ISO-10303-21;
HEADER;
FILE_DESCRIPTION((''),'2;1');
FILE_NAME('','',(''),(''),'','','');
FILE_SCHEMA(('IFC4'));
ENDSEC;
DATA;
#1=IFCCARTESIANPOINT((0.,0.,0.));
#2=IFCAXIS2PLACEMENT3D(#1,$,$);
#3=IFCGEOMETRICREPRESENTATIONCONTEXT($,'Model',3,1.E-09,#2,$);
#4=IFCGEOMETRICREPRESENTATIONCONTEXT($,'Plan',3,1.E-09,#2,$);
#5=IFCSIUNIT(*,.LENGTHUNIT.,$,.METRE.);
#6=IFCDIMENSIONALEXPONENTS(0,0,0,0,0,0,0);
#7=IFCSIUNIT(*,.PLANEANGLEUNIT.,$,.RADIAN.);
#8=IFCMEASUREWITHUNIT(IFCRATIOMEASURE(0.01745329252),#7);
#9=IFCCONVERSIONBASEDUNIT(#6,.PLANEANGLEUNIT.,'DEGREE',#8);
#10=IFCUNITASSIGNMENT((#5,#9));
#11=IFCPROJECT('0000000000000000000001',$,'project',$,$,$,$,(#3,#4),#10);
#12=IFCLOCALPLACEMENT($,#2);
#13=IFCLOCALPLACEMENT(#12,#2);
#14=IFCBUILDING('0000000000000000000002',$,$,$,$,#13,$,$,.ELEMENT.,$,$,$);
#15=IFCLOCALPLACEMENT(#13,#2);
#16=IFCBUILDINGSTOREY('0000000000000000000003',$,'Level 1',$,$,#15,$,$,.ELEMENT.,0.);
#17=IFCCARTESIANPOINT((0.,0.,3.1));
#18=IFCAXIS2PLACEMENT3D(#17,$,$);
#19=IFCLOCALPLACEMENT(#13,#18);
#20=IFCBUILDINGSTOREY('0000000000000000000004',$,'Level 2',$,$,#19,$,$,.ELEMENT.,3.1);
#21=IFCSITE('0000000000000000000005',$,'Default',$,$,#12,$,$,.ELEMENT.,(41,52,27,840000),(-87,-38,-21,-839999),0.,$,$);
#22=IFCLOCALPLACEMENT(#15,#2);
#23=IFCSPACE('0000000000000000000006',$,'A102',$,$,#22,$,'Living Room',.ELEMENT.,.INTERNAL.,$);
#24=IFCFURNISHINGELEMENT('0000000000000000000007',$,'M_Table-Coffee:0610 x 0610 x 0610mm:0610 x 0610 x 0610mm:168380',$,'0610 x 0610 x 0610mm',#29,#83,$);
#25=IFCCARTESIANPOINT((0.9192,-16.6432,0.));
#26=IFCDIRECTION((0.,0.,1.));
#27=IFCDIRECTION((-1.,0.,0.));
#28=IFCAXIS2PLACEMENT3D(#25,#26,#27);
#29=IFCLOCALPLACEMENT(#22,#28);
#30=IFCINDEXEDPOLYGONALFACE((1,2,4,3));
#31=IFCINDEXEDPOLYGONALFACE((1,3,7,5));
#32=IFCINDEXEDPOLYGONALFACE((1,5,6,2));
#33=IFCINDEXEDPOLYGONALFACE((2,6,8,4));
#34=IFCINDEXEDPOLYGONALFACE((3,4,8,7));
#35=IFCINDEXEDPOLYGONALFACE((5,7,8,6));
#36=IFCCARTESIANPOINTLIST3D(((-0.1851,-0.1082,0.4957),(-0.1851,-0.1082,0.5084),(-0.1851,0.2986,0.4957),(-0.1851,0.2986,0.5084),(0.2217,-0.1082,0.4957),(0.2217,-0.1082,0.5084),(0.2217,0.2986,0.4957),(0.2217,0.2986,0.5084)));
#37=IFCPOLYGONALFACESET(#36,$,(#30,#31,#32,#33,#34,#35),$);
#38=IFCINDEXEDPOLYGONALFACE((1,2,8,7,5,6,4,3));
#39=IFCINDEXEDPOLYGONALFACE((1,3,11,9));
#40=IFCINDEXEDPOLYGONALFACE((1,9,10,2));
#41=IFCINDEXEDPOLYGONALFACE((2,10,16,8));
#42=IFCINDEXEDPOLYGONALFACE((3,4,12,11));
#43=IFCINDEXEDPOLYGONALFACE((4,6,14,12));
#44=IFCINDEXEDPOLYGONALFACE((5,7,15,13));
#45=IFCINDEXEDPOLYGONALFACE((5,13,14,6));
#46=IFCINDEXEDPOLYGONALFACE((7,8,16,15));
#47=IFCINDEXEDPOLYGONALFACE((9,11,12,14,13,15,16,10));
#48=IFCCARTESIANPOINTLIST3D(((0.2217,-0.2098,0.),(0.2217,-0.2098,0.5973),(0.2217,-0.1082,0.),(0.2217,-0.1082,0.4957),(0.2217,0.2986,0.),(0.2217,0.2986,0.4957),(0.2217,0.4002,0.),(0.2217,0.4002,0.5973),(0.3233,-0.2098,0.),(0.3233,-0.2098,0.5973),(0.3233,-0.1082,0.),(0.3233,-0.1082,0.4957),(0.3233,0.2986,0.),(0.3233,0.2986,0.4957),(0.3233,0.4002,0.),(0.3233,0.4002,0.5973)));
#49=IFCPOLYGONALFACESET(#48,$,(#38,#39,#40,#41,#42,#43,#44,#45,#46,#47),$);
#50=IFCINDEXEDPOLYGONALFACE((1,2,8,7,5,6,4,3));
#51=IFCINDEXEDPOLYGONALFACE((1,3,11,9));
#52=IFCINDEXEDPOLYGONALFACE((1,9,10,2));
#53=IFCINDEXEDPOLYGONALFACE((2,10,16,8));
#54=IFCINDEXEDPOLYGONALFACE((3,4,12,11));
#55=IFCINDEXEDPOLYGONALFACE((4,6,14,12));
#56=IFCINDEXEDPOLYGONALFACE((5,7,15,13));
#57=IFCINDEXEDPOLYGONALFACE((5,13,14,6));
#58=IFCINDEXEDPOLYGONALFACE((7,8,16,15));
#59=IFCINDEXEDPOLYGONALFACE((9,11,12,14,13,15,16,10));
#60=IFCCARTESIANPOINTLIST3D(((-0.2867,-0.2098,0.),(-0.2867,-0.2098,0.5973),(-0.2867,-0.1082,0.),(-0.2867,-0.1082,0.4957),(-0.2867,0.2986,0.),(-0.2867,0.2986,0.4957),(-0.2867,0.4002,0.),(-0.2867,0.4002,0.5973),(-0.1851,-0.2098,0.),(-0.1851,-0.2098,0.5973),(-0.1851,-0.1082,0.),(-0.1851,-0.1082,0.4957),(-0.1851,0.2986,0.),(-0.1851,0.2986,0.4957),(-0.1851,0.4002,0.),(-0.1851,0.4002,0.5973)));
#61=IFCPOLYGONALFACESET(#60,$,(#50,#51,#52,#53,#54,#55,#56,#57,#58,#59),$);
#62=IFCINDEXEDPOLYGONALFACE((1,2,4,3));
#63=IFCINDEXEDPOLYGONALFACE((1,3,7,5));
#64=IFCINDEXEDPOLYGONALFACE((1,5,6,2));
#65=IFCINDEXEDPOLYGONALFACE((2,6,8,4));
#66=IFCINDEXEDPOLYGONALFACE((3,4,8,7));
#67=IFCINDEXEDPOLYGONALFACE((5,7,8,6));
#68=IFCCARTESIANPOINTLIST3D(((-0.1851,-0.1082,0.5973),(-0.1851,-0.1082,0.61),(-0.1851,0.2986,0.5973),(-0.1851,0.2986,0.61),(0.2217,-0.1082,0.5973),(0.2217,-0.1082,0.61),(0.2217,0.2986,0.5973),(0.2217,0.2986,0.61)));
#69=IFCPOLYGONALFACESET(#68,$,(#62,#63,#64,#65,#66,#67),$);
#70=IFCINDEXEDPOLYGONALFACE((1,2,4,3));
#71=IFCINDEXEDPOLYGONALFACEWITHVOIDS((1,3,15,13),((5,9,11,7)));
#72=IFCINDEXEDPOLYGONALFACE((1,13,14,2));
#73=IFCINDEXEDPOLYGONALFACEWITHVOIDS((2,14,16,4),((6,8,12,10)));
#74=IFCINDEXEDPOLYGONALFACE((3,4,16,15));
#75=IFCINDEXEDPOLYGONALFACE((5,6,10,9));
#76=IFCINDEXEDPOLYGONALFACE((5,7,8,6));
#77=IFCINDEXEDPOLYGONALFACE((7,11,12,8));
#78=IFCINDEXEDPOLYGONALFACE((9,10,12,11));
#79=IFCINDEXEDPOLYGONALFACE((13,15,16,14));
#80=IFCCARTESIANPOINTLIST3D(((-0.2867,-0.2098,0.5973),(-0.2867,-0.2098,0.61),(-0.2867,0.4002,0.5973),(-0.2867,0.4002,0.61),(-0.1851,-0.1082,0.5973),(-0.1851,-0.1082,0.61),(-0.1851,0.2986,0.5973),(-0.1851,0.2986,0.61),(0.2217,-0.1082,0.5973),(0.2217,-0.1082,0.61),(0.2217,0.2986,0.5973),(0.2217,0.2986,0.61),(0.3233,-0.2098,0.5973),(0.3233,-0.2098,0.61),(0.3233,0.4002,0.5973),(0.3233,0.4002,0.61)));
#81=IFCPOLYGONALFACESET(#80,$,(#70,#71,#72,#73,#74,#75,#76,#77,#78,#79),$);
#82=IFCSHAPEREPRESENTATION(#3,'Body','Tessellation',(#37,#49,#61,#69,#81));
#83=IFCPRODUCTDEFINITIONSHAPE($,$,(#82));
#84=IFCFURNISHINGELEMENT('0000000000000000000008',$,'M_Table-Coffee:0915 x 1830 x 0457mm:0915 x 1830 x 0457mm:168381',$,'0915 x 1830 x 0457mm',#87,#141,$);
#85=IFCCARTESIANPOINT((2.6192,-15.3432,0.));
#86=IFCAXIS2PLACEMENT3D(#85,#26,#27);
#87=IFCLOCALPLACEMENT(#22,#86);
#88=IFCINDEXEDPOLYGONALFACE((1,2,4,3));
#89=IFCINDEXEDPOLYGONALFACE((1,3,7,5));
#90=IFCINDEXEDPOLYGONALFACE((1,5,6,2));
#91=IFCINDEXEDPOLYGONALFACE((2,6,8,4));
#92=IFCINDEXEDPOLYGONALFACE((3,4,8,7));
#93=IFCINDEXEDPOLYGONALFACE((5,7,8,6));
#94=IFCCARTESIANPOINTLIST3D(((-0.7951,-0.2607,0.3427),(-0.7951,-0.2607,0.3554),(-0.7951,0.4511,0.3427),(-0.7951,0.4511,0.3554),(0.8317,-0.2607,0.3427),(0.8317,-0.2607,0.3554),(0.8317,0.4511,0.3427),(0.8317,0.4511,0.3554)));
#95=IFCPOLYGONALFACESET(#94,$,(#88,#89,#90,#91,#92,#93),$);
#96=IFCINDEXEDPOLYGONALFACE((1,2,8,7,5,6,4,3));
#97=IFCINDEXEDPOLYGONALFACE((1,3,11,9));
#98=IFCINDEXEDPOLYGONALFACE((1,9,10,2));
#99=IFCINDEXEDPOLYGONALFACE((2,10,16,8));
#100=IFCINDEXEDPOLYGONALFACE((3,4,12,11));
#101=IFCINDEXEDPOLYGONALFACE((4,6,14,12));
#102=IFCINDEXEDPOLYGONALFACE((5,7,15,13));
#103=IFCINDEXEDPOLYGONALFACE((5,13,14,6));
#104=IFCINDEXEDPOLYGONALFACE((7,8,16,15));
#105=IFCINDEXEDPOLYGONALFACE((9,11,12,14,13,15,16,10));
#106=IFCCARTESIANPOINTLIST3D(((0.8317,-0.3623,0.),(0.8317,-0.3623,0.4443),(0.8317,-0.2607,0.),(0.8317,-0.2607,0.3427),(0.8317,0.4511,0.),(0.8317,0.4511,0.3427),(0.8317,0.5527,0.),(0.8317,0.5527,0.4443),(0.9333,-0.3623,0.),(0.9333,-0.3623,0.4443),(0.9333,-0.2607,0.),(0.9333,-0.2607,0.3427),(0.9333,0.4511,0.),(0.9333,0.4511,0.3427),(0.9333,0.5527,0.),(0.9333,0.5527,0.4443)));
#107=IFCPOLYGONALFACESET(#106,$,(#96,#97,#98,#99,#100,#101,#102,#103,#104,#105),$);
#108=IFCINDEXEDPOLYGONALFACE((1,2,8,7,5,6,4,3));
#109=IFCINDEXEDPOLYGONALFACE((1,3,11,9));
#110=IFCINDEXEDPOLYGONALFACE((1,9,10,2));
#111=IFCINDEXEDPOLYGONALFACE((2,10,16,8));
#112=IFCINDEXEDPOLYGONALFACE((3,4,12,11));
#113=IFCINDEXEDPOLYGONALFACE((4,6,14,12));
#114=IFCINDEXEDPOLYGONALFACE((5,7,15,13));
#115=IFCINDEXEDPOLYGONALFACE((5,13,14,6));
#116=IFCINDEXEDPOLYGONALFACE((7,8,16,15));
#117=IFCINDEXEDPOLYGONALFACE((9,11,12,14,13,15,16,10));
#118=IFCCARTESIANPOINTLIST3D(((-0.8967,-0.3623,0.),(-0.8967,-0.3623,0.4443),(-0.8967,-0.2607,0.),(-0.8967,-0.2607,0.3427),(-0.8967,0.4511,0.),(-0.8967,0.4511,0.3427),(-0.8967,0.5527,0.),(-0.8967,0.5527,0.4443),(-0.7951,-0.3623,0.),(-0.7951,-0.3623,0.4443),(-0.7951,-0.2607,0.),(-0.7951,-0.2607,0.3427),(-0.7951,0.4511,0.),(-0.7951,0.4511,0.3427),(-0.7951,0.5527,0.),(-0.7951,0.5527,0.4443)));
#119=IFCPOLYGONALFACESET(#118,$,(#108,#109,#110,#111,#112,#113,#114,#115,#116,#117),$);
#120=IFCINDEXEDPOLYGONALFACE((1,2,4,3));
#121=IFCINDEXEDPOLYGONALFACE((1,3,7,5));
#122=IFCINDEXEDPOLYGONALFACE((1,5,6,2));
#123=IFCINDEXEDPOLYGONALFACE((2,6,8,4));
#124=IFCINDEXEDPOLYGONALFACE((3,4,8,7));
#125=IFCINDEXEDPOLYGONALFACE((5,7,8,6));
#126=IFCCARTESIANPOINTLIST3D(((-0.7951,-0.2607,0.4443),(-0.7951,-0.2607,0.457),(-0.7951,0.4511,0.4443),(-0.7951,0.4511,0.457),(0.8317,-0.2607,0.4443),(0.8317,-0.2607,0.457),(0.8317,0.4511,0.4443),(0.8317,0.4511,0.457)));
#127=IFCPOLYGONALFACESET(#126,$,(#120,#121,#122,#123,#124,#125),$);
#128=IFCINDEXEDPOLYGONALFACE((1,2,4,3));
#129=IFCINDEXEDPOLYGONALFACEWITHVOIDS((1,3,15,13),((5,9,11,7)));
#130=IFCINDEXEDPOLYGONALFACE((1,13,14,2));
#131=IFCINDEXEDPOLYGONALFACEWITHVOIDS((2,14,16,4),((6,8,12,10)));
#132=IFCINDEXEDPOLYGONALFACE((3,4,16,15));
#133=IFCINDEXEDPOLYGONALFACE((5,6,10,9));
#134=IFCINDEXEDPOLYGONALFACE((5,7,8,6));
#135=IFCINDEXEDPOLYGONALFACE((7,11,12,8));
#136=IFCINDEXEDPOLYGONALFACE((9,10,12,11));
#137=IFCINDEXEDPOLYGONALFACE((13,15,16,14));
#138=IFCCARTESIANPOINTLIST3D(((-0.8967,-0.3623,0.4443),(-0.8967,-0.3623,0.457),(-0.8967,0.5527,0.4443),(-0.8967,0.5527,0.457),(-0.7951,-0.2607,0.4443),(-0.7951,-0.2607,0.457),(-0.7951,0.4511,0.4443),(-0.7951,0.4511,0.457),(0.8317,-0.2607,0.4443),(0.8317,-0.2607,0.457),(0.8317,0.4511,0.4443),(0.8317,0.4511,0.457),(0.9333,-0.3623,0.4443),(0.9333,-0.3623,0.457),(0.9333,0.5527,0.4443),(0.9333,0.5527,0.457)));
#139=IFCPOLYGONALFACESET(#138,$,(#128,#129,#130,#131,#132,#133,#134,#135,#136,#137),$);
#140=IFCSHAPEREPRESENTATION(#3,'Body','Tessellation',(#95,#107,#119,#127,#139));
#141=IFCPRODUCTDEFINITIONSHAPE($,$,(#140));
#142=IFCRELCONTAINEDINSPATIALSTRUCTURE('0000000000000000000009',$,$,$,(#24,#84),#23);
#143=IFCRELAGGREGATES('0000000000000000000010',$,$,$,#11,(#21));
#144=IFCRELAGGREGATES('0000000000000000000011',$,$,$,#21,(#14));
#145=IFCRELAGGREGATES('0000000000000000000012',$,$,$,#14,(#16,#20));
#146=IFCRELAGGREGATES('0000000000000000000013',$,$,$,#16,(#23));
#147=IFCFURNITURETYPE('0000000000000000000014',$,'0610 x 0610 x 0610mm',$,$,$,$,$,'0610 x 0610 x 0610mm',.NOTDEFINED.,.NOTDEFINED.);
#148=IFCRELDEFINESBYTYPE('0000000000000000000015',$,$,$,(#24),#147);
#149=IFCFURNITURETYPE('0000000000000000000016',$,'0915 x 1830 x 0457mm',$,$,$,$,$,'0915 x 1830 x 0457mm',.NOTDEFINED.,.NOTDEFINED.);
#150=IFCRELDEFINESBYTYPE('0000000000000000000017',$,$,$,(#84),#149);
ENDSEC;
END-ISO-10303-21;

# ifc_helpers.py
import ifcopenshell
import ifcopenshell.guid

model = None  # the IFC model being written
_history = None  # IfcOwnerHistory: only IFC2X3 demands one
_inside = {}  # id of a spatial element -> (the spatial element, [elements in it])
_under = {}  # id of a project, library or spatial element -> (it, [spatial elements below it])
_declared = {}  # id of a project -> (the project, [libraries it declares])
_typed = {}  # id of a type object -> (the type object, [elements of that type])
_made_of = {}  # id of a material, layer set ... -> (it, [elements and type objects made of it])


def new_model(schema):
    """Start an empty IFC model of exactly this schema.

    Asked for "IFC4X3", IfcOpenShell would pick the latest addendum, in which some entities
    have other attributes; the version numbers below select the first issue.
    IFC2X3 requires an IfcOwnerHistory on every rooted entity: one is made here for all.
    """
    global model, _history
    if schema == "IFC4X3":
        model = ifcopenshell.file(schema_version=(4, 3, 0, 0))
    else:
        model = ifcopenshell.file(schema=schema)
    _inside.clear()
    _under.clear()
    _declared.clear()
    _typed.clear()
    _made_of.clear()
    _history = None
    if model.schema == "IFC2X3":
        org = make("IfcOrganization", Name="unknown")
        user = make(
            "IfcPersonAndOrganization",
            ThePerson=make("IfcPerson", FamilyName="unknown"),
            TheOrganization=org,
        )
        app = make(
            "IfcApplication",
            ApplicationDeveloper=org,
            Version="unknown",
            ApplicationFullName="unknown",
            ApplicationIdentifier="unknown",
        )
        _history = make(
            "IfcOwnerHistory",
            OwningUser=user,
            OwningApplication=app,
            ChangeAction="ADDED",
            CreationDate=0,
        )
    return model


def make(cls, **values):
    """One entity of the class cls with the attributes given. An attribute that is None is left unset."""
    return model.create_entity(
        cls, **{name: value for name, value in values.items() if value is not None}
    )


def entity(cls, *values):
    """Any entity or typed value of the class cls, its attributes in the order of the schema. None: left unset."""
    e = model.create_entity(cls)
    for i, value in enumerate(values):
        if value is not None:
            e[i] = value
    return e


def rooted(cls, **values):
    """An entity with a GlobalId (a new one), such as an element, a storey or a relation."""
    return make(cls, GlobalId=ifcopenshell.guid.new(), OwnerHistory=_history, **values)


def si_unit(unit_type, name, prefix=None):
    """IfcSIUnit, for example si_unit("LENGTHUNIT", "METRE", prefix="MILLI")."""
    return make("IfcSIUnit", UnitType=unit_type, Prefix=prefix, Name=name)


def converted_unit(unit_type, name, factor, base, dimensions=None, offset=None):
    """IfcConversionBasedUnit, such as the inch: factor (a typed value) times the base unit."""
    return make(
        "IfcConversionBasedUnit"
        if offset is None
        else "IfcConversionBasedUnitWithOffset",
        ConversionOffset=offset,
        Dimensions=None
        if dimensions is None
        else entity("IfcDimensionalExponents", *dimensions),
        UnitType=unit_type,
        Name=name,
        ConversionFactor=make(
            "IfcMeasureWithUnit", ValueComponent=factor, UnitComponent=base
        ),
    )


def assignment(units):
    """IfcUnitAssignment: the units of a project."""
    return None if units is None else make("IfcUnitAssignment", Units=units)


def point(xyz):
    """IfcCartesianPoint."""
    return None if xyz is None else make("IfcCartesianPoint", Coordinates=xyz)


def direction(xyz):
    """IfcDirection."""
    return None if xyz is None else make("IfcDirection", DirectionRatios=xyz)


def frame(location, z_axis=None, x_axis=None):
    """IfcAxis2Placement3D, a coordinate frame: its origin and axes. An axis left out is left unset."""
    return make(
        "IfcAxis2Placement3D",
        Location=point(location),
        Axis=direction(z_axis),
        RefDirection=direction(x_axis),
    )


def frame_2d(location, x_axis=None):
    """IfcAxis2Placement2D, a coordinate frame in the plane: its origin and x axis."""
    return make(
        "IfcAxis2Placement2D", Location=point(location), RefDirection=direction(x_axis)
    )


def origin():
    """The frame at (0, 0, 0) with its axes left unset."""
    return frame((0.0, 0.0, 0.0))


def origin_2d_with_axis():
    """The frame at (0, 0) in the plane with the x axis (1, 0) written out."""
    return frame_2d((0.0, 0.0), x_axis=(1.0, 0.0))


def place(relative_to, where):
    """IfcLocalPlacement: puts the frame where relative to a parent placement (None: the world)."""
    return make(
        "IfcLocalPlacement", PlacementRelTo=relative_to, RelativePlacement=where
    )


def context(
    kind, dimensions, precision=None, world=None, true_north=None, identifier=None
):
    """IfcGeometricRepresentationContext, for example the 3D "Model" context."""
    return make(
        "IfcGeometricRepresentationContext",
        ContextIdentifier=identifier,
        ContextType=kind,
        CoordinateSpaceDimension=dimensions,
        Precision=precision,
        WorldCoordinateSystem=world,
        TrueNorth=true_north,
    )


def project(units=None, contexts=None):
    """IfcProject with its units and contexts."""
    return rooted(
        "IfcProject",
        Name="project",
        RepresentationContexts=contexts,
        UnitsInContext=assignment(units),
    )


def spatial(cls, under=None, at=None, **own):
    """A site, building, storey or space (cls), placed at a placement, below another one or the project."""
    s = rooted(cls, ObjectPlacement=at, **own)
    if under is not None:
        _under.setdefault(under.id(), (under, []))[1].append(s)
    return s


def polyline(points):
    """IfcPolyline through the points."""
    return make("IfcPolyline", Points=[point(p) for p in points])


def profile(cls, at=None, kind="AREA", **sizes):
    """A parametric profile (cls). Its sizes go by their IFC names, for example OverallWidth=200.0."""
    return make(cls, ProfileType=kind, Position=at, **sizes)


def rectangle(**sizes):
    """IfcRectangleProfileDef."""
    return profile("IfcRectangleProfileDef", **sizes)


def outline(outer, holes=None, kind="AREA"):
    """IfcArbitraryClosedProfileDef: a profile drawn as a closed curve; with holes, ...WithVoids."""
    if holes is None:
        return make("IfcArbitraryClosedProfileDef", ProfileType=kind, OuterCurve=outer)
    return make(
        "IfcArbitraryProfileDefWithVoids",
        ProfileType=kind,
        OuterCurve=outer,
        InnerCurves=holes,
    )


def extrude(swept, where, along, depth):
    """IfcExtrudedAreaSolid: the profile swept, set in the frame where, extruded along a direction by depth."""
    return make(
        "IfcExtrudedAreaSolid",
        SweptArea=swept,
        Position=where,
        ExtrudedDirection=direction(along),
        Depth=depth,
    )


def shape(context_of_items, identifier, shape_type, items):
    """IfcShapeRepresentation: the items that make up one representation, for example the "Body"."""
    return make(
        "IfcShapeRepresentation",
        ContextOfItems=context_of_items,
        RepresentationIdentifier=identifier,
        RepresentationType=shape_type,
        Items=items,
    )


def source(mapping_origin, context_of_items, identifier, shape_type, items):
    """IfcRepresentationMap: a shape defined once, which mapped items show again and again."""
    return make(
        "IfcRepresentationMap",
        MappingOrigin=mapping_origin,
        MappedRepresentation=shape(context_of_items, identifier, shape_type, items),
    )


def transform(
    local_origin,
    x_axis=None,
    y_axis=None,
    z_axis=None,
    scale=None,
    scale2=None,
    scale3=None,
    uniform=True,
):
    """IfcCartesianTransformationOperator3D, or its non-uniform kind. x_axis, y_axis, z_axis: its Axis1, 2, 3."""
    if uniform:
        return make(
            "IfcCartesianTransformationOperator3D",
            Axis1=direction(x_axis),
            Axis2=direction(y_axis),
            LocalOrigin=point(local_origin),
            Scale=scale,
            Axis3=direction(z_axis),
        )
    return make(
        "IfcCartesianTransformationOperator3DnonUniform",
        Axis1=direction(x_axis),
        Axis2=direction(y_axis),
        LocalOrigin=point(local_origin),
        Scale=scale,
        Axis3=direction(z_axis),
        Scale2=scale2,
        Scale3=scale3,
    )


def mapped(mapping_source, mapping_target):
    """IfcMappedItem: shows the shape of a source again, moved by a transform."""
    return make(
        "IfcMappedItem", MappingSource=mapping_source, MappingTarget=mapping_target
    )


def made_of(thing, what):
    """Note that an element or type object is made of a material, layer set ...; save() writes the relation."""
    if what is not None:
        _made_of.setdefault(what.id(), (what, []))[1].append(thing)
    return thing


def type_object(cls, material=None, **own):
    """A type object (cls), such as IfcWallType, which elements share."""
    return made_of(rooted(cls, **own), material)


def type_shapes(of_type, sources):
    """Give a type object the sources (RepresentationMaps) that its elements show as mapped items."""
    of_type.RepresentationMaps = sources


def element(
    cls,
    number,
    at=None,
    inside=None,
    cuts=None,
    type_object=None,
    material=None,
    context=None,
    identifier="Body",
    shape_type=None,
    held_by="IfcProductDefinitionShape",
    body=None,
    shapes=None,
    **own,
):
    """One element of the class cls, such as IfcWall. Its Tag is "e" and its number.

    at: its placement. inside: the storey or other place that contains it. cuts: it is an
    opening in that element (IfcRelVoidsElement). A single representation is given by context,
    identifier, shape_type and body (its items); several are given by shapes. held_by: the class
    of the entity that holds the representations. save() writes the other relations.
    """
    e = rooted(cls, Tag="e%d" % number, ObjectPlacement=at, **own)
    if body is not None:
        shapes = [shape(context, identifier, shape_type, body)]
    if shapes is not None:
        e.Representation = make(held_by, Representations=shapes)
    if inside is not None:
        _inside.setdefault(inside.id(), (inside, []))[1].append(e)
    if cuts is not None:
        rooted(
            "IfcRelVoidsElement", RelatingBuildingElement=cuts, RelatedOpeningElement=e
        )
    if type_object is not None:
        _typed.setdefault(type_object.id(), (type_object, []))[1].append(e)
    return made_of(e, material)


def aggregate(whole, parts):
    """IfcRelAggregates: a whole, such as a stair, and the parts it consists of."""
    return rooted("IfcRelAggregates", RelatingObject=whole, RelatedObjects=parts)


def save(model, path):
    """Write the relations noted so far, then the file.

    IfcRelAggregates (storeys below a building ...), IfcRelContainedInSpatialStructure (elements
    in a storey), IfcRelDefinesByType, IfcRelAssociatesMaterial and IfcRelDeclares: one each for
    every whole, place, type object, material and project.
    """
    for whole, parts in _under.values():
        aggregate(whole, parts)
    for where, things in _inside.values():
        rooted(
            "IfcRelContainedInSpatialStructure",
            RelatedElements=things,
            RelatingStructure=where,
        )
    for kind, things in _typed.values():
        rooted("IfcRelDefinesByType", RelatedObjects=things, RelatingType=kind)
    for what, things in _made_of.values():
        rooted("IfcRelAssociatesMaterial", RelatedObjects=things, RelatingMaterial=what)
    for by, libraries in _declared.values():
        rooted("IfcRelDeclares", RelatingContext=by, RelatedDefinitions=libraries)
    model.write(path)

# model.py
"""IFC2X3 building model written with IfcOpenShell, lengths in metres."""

from ifc_helpers import new_model, entity, si_unit, converted_unit, frame, origin, origin_2d_with_axis, place, context, project, spatial, polyline, rectangle, outline, extrude, source, transform, mapped, type_object, type_shapes, element, save


model = new_model("IFC2X3")

# Units and contexts
model_context = context("Model", 3, precision=1e-09, world=origin())
plan_context = context("Plan", 3, precision=1e-09, world=origin())
ifc_project = project(units=[si_unit("LENGTHUNIT", "METRE"), converted_unit("PLANEANGLEUNIT", "DEGREE", entity("IfcRatioMeasure", 0.01745329252), si_unit("PLANEANGLEUNIT", "RADIAN"), dimensions=[0, 0, 0, 0, 0, 0, 0])], contexts=[model_context, plan_context])

# Site, building, storey
site_placement = place(None, origin())
site = spatial("IfcSite", under=ifc_project, at=site_placement, Name="Default", CompositionType="ELEMENT", RefLatitude=(41, 52, 27, 840000), RefLongitude=(-87, -38, -21, -839999), RefElevation=0.0)
building_placement = place(site_placement, origin())
building = spatial("IfcBuilding", under=site, at=building_placement, CompositionType="ELEMENT")
storey_1_placement = place(building_placement, origin())
storey_1 = spatial("IfcBuildingStorey", under=building, at=storey_1_placement, Name="Level 1", CompositionType="ELEMENT", Elevation=0.0)

# Shared definitions
storey_2_placement = place(building_placement, frame((0.0, 0.0, 3.1)))
storey_2 = spatial("IfcBuildingStorey", under=building, at=storey_2_placement, Name="Level 2", CompositionType="ELEMENT", Elevation=3.1)

# Shared definitions
space_1_placement = place(storey_1_placement, origin())
space_1 = spatial("IfcSpace", under=storey_1, at=space_1_placement, Name="A102", LongName="Living Room", CompositionType="ELEMENT", InteriorOrExteriorSpace="INTERNAL")

# Furnishing elements
furniture_type_1 = type_object("IfcFurnitureType", Name="0610 x 0610 x 0610mm", ElementType="0610 x 0610 x 0610mm", AssemblyPlace="NOTDEFINED")
shared_shape_1 = source(origin(), model_context, "Body", "SweptSolid", [
    extrude(rectangle(XDim=0.4068, YDim=0.4068, at=origin_2d_with_axis()), frame((0.0183, 0.0952, 0.4957), z_axis=(0.0, 0.0, 1.0), x_axis=(-1.0, 0.0, 0.0)), (0.0, 0.0, 1.0), 0.0127),
    extrude(outline(polyline([(-0.2732, -0.305), (0.3241, -0.305), (0.3241, 0.305), (-0.2732, 0.305), (-0.2732, 0.2034), (0.2225, 0.2034), (0.2225, -0.2034), (-0.2732, -0.2034), (-0.2732, -0.305)])), frame((0.2217, 0.0952, 0.2732), z_axis=(1.0, 0.0, 0.0), x_axis=(0.0, 0.0, 1.0)), (0.0, 0.0, 1.0), 0.1016),
    extrude(outline(polyline([(-0.305, -0.3241), (0.305, -0.3241), (0.305, 0.2732), (0.2034, 0.2732), (0.2034, -0.2225), (-0.2034, -0.2225), (-0.2034, 0.2732), (-0.305, 0.2732), (-0.305, -0.3241)])), frame((-0.2867, 0.0952, 0.2732), z_axis=(1.0, 0.0, 0.0), x_axis=(0.0, -1.0, 0.0)), (0.0, 0.0, 1.0), 0.1016),
    extrude(rectangle(XDim=0.4068, YDim=0.4068, at=origin_2d_with_axis()), frame((0.0183, 0.0952, 0.5973), z_axis=(0.0, 0.0, 1.0), x_axis=(-1.0, 0.0, 0.0)), (0.0, 0.0, 1.0), 0.0127),
    extrude(outline(polyline([(-0.305, -0.305), (0.305, -0.305), (0.305, 0.305), (-0.305, 0.305), (-0.305, -0.305)]), holes=[polyline([(-0.2034, -0.2034), (-0.2034, 0.2034), (0.2034, 0.2034), (0.2034, -0.2034), (-0.2034, -0.2034)])]), frame((0.0183, 0.0952, 0.5973), z_axis=(0.0, 0.0, 1.0), x_axis=(-1.0, 0.0, 0.0)), (0.0, 0.0, 1.0), 0.0127),
])
type_shapes(furniture_type_1, [shared_shape_1])
for number, where, z_axis, x_axis, name in (
    (1, (0.9192, -16.6432, 0.0), (0.0, 0.0, 1.0), (-1.0, 0.0, 0.0), "M_Table-Coffee:0610 x 0610 x 0610mm:0610 x 0610 x 0610mm:168380"),
):
    element("IfcFurnishingElement", number, at=place(space_1_placement, frame(where, z_axis=z_axis, x_axis=x_axis)), inside=space_1, type_object=furniture_type_1, Name=name, ObjectType="0610 x 0610 x 0610mm", context=model_context, shape_type="MappedRepresentation", body=[
        mapped(shared_shape_1, transform((0.0, 0.0, 0.0), scale=1.0)),
    ])
furniture_type_2 = type_object("IfcFurnitureType", Name="0915 x 1830 x 0457mm", ElementType="0915 x 1830 x 0457mm", AssemblyPlace="NOTDEFINED")
shared_shape_2 = source(origin(), model_context, "Body", "SweptSolid", [
    extrude(rectangle(XDim=1.6268, YDim=0.7118, at=origin_2d_with_axis()), frame((0.0183, 0.0952, 0.3427), z_axis=(0.0, 0.0, 1.0), x_axis=(-1.0, 0.0, 0.0)), (0.0, 0.0, 1.0), 0.0127),
    extrude(outline(polyline([(-0.1968, -0.4575), (0.2475, -0.4575), (0.2475, 0.4575), (-0.1968, 0.4575), (-0.1968, 0.3559), (0.1459, 0.3559), (0.1459, -0.3559), (-0.1968, -0.3559), (-0.1968, -0.4575)])), frame((0.8317, 0.0952, 0.1968), z_axis=(1.0, 0.0, 0.0), x_axis=(0.0, 0.0, 1.0)), (0.0, 0.0, 1.0), 0.1016),
    extrude(outline(polyline([(-0.4575, -0.2475), (0.4575, -0.2475), (0.4575, 0.1968), (0.3559, 0.1968), (0.3559, -0.1459), (-0.3559, -0.1459), (-0.3559, 0.1968), (-0.4575, 0.1968), (-0.4575, -0.2475)])), frame((-0.8967, 0.0952, 0.1968), z_axis=(1.0, 0.0, 0.0), x_axis=(0.0, -1.0, 0.0)), (0.0, 0.0, 1.0), 0.1016),
    extrude(rectangle(XDim=1.6268, YDim=0.7118, at=origin_2d_with_axis()), frame((0.0183, 0.0952, 0.4443), z_axis=(0.0, 0.0, 1.0), x_axis=(-1.0, 0.0, 0.0)), (0.0, 0.0, 1.0), 0.0127),
    extrude(outline(polyline([(-0.915, -0.4575), (0.915, -0.4575), (0.915, 0.4575), (-0.915, 0.4575), (-0.915, -0.4575)]), holes=[polyline([(-0.8134, -0.3559), (-0.8134, 0.3559), (0.8134, 0.3559), (0.8134, -0.3559), (-0.8134, -0.3559)])]), frame((0.0183, 0.0952, 0.4443), z_axis=(0.0, 0.0, 1.0), x_axis=(-1.0, 0.0, 0.0)), (0.0, 0.0, 1.0), 0.0127),
])
type_shapes(furniture_type_2, [shared_shape_2])
furnishing_1_placement = place(space_1_placement, frame((2.6192, -15.3432, 0.0), z_axis=(0.0, 0.0, 1.0), x_axis=(-1.0, 0.0, 0.0)))
element("IfcFurnishingElement", 2, at=furnishing_1_placement, inside=space_1, type_object=furniture_type_2, Name="M_Table-Coffee:0915 x 1830 x 0457mm:0915 x 1830 x 0457mm:168381", ObjectType="0915 x 1830 x 0457mm", context=model_context, shape_type="MappedRepresentation", body=[
    mapped(shared_shape_2, transform((0.0, 0.0, 0.0), scale=1.0)),
])

save(model, "model.ifc")
